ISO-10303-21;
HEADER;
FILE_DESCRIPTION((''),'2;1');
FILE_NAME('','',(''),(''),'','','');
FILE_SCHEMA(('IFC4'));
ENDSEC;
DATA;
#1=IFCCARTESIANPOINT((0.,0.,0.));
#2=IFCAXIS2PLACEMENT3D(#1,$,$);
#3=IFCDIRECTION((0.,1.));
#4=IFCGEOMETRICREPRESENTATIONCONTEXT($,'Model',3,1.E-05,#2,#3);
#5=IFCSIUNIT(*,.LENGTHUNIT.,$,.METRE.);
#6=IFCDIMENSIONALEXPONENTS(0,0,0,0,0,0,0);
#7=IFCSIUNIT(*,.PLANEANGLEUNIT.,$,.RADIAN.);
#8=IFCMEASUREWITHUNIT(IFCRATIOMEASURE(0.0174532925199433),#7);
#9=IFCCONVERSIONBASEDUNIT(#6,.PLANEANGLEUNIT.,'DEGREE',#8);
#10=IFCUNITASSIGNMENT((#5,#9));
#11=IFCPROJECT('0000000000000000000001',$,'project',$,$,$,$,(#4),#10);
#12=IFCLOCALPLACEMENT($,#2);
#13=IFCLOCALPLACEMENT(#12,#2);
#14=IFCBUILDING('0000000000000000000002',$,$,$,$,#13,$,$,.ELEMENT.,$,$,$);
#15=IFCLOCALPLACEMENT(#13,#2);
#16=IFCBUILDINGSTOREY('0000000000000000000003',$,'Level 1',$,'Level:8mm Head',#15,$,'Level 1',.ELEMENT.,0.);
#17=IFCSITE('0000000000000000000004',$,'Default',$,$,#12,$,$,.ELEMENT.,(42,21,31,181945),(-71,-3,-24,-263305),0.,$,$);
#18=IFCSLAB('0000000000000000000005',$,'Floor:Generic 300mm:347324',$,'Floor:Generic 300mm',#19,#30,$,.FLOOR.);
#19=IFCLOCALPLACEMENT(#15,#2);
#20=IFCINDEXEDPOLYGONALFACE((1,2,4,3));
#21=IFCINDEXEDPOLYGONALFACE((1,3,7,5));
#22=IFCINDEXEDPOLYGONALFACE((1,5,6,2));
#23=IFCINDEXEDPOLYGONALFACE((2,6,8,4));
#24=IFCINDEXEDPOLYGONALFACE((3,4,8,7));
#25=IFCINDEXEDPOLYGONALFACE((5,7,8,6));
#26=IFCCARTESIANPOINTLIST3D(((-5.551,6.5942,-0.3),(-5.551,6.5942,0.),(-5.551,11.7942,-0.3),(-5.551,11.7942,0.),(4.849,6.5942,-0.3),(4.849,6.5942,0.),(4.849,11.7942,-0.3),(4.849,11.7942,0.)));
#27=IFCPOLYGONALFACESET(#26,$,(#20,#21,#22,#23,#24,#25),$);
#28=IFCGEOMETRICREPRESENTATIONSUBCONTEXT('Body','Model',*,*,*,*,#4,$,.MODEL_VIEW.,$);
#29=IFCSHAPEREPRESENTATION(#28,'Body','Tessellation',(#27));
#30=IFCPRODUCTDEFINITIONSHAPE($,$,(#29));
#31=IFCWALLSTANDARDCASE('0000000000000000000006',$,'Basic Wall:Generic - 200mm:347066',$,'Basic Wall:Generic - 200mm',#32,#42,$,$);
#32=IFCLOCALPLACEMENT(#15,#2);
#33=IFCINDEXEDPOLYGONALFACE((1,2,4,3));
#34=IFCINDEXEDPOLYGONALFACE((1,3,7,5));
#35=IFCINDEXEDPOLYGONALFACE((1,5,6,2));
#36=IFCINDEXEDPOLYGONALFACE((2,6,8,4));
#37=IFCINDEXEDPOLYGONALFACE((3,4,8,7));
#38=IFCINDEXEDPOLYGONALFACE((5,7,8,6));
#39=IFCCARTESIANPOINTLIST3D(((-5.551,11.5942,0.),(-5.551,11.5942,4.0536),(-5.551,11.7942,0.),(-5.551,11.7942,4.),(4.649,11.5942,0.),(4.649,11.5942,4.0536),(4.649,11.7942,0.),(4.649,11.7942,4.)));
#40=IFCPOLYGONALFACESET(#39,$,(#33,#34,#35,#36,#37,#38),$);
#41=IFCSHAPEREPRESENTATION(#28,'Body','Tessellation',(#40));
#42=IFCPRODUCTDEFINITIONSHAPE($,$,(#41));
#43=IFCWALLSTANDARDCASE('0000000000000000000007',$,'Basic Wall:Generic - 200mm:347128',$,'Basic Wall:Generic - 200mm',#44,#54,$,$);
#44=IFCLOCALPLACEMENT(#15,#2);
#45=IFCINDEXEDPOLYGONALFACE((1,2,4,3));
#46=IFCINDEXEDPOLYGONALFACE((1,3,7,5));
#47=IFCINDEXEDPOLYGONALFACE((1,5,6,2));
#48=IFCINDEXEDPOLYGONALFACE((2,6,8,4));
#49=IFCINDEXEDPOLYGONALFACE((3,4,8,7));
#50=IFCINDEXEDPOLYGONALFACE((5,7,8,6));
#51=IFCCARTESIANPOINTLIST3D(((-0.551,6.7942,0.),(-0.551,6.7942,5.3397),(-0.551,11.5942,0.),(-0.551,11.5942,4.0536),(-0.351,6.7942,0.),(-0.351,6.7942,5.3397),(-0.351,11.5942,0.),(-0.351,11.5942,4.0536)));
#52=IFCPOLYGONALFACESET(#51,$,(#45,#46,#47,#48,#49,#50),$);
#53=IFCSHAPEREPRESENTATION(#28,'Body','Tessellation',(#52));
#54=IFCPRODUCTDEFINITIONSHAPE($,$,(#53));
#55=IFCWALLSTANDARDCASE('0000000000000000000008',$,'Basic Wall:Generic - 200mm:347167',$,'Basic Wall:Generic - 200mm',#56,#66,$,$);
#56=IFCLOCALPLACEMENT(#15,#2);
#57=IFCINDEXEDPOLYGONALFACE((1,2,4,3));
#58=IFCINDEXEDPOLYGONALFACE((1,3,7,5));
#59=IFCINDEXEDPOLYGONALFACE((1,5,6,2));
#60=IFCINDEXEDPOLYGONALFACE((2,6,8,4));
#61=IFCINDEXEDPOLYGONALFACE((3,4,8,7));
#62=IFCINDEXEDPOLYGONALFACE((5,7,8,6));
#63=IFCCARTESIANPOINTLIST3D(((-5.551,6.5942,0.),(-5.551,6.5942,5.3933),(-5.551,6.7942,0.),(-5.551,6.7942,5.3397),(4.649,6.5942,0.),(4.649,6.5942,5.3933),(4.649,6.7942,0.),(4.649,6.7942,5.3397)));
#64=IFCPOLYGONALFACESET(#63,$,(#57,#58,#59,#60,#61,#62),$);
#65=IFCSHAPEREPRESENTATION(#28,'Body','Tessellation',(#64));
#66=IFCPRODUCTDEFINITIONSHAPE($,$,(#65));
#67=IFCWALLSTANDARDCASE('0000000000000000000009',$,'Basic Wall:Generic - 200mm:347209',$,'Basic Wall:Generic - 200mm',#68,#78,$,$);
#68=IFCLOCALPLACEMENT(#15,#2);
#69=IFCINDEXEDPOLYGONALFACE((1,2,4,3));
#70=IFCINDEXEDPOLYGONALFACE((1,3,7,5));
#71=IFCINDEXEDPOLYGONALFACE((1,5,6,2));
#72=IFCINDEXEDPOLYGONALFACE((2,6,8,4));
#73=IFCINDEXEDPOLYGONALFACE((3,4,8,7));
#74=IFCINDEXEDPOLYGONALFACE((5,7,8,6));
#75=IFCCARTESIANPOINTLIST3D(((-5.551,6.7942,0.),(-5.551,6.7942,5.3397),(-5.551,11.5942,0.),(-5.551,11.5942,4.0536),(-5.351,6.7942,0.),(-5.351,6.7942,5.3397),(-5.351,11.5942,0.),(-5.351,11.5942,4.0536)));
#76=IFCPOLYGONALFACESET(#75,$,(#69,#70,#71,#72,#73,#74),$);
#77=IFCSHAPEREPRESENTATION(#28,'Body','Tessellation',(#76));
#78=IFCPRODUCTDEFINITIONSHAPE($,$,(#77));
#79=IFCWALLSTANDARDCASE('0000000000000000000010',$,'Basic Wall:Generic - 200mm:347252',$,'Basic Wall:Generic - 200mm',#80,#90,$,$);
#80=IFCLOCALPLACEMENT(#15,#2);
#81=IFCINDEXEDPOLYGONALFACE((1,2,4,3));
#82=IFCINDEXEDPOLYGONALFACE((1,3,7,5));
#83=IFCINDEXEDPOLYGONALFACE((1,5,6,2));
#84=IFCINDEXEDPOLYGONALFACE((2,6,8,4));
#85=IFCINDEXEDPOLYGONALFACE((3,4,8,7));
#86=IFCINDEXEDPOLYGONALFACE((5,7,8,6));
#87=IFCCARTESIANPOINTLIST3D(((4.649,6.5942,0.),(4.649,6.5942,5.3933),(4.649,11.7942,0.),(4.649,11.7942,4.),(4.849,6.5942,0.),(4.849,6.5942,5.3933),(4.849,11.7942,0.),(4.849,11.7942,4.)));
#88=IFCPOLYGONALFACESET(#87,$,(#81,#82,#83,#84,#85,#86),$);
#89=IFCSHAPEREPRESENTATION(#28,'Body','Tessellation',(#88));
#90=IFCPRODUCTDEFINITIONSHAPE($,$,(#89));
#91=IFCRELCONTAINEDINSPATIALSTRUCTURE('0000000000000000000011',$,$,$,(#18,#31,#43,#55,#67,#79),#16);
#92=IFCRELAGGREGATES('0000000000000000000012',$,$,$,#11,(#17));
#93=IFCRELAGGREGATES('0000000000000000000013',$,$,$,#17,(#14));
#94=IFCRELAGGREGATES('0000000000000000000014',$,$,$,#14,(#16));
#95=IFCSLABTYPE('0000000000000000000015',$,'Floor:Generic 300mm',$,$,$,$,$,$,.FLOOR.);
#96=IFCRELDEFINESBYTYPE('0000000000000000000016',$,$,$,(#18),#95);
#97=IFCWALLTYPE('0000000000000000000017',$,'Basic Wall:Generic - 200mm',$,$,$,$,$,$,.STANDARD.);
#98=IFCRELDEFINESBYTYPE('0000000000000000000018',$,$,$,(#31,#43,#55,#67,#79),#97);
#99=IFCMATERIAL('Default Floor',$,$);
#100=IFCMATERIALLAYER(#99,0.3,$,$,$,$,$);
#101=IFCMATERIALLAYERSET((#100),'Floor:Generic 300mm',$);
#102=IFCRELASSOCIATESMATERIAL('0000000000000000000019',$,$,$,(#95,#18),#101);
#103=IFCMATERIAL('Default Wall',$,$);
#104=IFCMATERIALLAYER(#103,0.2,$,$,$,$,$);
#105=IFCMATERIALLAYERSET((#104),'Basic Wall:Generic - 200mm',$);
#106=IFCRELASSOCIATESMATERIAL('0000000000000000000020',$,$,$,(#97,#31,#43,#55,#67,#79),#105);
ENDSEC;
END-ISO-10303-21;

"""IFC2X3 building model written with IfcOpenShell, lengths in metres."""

from ifc_helpers import new_model, entity, si_unit, converted_unit, direction, frame, frame_2d, origin, origin_2d_with_axis, place, context, subcontext, project, spatial, polyline, rectangle, extrude, clip, bounded_halfspace, material, layer, layer_set, layer_usage, type_object, element, save


model = new_model("IFC2X3")

# Units and contexts
model_context = context("Model", 3, precision=1e-05, world=origin(), true_north=direction((0.0, 1.0)))
body_context = subcontext(model_context, "Body", "Model", "MODEL_VIEW")
ifc_project = project(units=[si_unit("LENGTHUNIT", "METRE"), converted_unit("PLANEANGLEUNIT", "DEGREE", entity("IfcRatioMeasure", 0.0174532925199433), si_unit("PLANEANGLEUNIT", "RADIAN"), dimensions=[0, 0, 0, 0, 0, 0, 0])], contexts=[model_context])

# Site, building, storey
site_placement = place(None, origin())
site = spatial("IfcSite", under=ifc_project, at=site_placement, Name="Default", CompositionType="ELEMENT", RefLatitude=(42, 21, 31, 181945), RefLongitude=(-71, -3, -24, -263305), RefElevation=0.0)
building_placement = place(site_placement, origin())
building = spatial("IfcBuilding", under=site, at=building_placement, CompositionType="ELEMENT")
storey_placement = place(building_placement, origin())
storey = spatial("IfcBuildingStorey", under=building, at=storey_placement, Name="Level 1", ObjectType="Level:8mm Head", LongName="Level 1", CompositionType="ELEMENT", Elevation=0.0)

# Slab
ifc_material_1 = material(Name="Default Floor")
ifc_layer_1 = layer(ifc_material_1, 0.3)
ifc_layer_set_1 = layer_set([ifc_layer_1], Name="Floor:Generic 300mm")
ifc_layer_usage_1 = layer_usage(ifc_layer_set_1, "AXIS3", "POSITIVE", 0.0)
slab_type = type_object("IfcSlabType", Name="Floor:Generic 300mm", PredefinedType="FLOOR", material=ifc_layer_set_1)
slab_placement = place(storey_placement, origin())
element("IfcSlab", 1, at=slab_placement, inside=storey, type_object=slab_type, material=ifc_layer_usage_1, Name="Floor:Generic 300mm:347324", ObjectType="Floor:Generic 300mm", PredefinedType="FLOOR", context=body_context, shape_type="SweptSolid", body=[
    extrude(rectangle(XDim=5.2, YDim=10.4, at=origin_2d_with_axis()), frame((-0.351, 9.1942, 0.0), z_axis=(0.0, 0.0, -1.0), x_axis=(0.0, 1.0, 0.0)), (0.0, 0.0, 1.0), 0.3),
])

# Walls
ifc_material_2 = material(Name="Default Wall")
ifc_layer_2 = layer(ifc_material_2, 0.2)
ifc_layer_set_2 = layer_set([ifc_layer_2], Name="Basic Wall:Generic - 200mm")
ifc_layer_usage_2 = layer_usage(ifc_layer_set_2, "AXIS2", "NEGATIVE", 0.1)
wall_type = type_object("IfcWallType", Name="Basic Wall:Generic - 200mm", PredefinedType="STANDARD", material=ifc_layer_set_2)
wall_1_placement = place(storey_placement, frame((-5.551, 11.6942, 0.0)))
element("IfcWallStandardCase", 2, at=wall_1_placement, inside=storey, type_object=wall_type, material=ifc_layer_usage_2, Name="Basic Wall:Generic - 200mm:347066", ObjectType="Basic Wall:Generic - 200mm", context=body_context, shape_type="Clipping", body=[
    clip(extrude(rectangle(XDim=10.2, YDim=0.2, at=frame_2d((5.1, 0.0), x_axis=(-1.0, 0.0))), origin(), (0.0, 0.0, 1.0), 4.0536), bounded_halfspace(frame((0.0, -0.1, 4.0536), z_axis=(0.0, 0.258819, 0.965926), x_axis=(-1.0, 0.0, 0.0)), False, frame((0.0, -0.1, 4.0536)), polyline([(0.0, 0.0), (0.2, 0.0), (5.0, 0.0), (5.2, 0.0), (10.2, 0.0), (10.2, 0.2), (0.0, 0.2), (0.0, 0.0)]))),
])
ifc_layer_usage_3 = layer_usage(ifc_layer_set_2, "AXIS2", "NEGATIVE", 0.1)
wall_2_placement = place(storey_placement, frame((-0.451, 11.5942, 0.0), z_axis=(0.0, 0.0, 1.0), x_axis=(0.0, -1.0, 0.0)))
element("IfcWallStandardCase", 3, at=wall_2_placement, inside=storey, type_object=wall_type, material=ifc_layer_usage_3, Name="Basic Wall:Generic - 200mm:347128", ObjectType="Basic Wall:Generic - 200mm", context=body_context, shape_type="Clipping", body=[
    clip(extrude(rectangle(XDim=4.8, YDim=0.2, at=frame_2d((2.4, 0.0), x_axis=(-1.0, 0.0))), origin(), (0.0, 0.0, 1.0), 5.3397), bounded_halfspace(frame((0.0, -0.1, 4.0536), z_axis=(-0.258819, 0.0, 0.965926), x_axis=(0.0, -1.0, 0.0)), False, frame((0.0, -0.1, 4.0536)), polyline([(0.0, 0.0), (4.8, 0.0), (4.8, 0.2), (0.0, 0.2), (0.0, 0.0)]))),
])
ifc_layer_usage_4 = layer_usage(ifc_layer_set_2, "AXIS2", "NEGATIVE", 0.1)
wall_3_placement = place(storey_placement, frame((4.649, 6.6942, 0.0), z_axis=(0.0, 0.0, 1.0), x_axis=(-1.0, 0.0, 0.0)))
element("IfcWallStandardCase", 4, at=wall_3_placement, inside=storey, type_object=wall_type, material=ifc_layer_usage_4, Name="Basic Wall:Generic - 200mm:347167", ObjectType="Basic Wall:Generic - 200mm", context=body_context, shape_type="Clipping", body=[
    clip(extrude(rectangle(XDim=10.2, YDim=0.2, at=frame_2d((5.1, 0.0), x_axis=(-1.0, 0.0))), origin(), (0.0, 0.0, 1.0), 5.3933), bounded_halfspace(frame((0.0, -0.1, 5.3397), z_axis=(0.0, -0.258819, 0.965926), x_axis=(1.0, 0.0, 0.0)), False, frame((0.0, -0.1, 5.3397)), polyline([(0.0, 0.0), (5.0, 0.0), (5.2, 0.0), (10.0, 0.0), (10.2, 0.0), (10.2, 0.2), (0.0, 0.2), (0.0, 0.0)]))),
])
ifc_layer_usage_5 = layer_usage(ifc_layer_set_2, "AXIS2", "NEGATIVE", 0.1)
wall_4_placement = place(storey_placement, frame((-5.451, 6.7942, 0.0), z_axis=(0.0, 0.0, 1.0), x_axis=(0.0, 1.0, 0.0)))
element("IfcWallStandardCase", 5, at=wall_4_placement, inside=storey, type_object=wall_type, material=ifc_layer_usage_5, Name="Basic Wall:Generic - 200mm:347209", ObjectType="Basic Wall:Generic - 200mm", context=body_context, shape_type="Clipping", body=[
    clip(extrude(rectangle(XDim=4.8, YDim=0.2, at=frame_2d((2.4, 0.0), x_axis=(-1.0, 0.0))), origin(), (0.0, 0.0, 1.0), 5.3397), bounded_halfspace(frame((0.0, -0.1, 5.3397), z_axis=(0.258819, 0.0, 0.965926), x_axis=(0.0, 1.0, 0.0)), False, frame((0.0, -0.1, 5.3397)), polyline([(0.0, 0.0), (4.8, 0.0), (4.8, 0.2), (0.0, 0.2), (0.0, 0.0)]))),
])
ifc_layer_usage_6 = layer_usage(ifc_layer_set_2, "AXIS2", "NEGATIVE", 0.1)
wall_5_placement = place(storey_placement, frame((4.749, 11.7942, 0.0), z_axis=(0.0, 0.0, 1.0), x_axis=(0.0, -1.0, 0.0)))
element("IfcWallStandardCase", 6, at=wall_5_placement, inside=storey, type_object=wall_type, material=ifc_layer_usage_6, Name="Basic Wall:Generic - 200mm:347252", ObjectType="Basic Wall:Generic - 200mm", context=body_context, shape_type="Clipping", body=[
    clip(extrude(rectangle(XDim=5.2, YDim=0.2, at=frame_2d((2.6, 0.0), x_axis=(-1.0, 0.0))), origin(), (0.0, 0.0, 1.0), 5.3933), bounded_halfspace(frame((0.0, -0.1, 4.0), z_axis=(-0.258819, 0.0, 0.965926), x_axis=(0.0, -1.0, 0.0)), False, frame((0.0, -0.1, 4.0)), polyline([(0.0, 0.0), (0.2, 0.0), (5.0, 0.0), (5.2, 0.0), (5.2, 0.2), (0.0, 0.2), (0.0, 0.0)]))),
])

save(model, "model.ifc")
